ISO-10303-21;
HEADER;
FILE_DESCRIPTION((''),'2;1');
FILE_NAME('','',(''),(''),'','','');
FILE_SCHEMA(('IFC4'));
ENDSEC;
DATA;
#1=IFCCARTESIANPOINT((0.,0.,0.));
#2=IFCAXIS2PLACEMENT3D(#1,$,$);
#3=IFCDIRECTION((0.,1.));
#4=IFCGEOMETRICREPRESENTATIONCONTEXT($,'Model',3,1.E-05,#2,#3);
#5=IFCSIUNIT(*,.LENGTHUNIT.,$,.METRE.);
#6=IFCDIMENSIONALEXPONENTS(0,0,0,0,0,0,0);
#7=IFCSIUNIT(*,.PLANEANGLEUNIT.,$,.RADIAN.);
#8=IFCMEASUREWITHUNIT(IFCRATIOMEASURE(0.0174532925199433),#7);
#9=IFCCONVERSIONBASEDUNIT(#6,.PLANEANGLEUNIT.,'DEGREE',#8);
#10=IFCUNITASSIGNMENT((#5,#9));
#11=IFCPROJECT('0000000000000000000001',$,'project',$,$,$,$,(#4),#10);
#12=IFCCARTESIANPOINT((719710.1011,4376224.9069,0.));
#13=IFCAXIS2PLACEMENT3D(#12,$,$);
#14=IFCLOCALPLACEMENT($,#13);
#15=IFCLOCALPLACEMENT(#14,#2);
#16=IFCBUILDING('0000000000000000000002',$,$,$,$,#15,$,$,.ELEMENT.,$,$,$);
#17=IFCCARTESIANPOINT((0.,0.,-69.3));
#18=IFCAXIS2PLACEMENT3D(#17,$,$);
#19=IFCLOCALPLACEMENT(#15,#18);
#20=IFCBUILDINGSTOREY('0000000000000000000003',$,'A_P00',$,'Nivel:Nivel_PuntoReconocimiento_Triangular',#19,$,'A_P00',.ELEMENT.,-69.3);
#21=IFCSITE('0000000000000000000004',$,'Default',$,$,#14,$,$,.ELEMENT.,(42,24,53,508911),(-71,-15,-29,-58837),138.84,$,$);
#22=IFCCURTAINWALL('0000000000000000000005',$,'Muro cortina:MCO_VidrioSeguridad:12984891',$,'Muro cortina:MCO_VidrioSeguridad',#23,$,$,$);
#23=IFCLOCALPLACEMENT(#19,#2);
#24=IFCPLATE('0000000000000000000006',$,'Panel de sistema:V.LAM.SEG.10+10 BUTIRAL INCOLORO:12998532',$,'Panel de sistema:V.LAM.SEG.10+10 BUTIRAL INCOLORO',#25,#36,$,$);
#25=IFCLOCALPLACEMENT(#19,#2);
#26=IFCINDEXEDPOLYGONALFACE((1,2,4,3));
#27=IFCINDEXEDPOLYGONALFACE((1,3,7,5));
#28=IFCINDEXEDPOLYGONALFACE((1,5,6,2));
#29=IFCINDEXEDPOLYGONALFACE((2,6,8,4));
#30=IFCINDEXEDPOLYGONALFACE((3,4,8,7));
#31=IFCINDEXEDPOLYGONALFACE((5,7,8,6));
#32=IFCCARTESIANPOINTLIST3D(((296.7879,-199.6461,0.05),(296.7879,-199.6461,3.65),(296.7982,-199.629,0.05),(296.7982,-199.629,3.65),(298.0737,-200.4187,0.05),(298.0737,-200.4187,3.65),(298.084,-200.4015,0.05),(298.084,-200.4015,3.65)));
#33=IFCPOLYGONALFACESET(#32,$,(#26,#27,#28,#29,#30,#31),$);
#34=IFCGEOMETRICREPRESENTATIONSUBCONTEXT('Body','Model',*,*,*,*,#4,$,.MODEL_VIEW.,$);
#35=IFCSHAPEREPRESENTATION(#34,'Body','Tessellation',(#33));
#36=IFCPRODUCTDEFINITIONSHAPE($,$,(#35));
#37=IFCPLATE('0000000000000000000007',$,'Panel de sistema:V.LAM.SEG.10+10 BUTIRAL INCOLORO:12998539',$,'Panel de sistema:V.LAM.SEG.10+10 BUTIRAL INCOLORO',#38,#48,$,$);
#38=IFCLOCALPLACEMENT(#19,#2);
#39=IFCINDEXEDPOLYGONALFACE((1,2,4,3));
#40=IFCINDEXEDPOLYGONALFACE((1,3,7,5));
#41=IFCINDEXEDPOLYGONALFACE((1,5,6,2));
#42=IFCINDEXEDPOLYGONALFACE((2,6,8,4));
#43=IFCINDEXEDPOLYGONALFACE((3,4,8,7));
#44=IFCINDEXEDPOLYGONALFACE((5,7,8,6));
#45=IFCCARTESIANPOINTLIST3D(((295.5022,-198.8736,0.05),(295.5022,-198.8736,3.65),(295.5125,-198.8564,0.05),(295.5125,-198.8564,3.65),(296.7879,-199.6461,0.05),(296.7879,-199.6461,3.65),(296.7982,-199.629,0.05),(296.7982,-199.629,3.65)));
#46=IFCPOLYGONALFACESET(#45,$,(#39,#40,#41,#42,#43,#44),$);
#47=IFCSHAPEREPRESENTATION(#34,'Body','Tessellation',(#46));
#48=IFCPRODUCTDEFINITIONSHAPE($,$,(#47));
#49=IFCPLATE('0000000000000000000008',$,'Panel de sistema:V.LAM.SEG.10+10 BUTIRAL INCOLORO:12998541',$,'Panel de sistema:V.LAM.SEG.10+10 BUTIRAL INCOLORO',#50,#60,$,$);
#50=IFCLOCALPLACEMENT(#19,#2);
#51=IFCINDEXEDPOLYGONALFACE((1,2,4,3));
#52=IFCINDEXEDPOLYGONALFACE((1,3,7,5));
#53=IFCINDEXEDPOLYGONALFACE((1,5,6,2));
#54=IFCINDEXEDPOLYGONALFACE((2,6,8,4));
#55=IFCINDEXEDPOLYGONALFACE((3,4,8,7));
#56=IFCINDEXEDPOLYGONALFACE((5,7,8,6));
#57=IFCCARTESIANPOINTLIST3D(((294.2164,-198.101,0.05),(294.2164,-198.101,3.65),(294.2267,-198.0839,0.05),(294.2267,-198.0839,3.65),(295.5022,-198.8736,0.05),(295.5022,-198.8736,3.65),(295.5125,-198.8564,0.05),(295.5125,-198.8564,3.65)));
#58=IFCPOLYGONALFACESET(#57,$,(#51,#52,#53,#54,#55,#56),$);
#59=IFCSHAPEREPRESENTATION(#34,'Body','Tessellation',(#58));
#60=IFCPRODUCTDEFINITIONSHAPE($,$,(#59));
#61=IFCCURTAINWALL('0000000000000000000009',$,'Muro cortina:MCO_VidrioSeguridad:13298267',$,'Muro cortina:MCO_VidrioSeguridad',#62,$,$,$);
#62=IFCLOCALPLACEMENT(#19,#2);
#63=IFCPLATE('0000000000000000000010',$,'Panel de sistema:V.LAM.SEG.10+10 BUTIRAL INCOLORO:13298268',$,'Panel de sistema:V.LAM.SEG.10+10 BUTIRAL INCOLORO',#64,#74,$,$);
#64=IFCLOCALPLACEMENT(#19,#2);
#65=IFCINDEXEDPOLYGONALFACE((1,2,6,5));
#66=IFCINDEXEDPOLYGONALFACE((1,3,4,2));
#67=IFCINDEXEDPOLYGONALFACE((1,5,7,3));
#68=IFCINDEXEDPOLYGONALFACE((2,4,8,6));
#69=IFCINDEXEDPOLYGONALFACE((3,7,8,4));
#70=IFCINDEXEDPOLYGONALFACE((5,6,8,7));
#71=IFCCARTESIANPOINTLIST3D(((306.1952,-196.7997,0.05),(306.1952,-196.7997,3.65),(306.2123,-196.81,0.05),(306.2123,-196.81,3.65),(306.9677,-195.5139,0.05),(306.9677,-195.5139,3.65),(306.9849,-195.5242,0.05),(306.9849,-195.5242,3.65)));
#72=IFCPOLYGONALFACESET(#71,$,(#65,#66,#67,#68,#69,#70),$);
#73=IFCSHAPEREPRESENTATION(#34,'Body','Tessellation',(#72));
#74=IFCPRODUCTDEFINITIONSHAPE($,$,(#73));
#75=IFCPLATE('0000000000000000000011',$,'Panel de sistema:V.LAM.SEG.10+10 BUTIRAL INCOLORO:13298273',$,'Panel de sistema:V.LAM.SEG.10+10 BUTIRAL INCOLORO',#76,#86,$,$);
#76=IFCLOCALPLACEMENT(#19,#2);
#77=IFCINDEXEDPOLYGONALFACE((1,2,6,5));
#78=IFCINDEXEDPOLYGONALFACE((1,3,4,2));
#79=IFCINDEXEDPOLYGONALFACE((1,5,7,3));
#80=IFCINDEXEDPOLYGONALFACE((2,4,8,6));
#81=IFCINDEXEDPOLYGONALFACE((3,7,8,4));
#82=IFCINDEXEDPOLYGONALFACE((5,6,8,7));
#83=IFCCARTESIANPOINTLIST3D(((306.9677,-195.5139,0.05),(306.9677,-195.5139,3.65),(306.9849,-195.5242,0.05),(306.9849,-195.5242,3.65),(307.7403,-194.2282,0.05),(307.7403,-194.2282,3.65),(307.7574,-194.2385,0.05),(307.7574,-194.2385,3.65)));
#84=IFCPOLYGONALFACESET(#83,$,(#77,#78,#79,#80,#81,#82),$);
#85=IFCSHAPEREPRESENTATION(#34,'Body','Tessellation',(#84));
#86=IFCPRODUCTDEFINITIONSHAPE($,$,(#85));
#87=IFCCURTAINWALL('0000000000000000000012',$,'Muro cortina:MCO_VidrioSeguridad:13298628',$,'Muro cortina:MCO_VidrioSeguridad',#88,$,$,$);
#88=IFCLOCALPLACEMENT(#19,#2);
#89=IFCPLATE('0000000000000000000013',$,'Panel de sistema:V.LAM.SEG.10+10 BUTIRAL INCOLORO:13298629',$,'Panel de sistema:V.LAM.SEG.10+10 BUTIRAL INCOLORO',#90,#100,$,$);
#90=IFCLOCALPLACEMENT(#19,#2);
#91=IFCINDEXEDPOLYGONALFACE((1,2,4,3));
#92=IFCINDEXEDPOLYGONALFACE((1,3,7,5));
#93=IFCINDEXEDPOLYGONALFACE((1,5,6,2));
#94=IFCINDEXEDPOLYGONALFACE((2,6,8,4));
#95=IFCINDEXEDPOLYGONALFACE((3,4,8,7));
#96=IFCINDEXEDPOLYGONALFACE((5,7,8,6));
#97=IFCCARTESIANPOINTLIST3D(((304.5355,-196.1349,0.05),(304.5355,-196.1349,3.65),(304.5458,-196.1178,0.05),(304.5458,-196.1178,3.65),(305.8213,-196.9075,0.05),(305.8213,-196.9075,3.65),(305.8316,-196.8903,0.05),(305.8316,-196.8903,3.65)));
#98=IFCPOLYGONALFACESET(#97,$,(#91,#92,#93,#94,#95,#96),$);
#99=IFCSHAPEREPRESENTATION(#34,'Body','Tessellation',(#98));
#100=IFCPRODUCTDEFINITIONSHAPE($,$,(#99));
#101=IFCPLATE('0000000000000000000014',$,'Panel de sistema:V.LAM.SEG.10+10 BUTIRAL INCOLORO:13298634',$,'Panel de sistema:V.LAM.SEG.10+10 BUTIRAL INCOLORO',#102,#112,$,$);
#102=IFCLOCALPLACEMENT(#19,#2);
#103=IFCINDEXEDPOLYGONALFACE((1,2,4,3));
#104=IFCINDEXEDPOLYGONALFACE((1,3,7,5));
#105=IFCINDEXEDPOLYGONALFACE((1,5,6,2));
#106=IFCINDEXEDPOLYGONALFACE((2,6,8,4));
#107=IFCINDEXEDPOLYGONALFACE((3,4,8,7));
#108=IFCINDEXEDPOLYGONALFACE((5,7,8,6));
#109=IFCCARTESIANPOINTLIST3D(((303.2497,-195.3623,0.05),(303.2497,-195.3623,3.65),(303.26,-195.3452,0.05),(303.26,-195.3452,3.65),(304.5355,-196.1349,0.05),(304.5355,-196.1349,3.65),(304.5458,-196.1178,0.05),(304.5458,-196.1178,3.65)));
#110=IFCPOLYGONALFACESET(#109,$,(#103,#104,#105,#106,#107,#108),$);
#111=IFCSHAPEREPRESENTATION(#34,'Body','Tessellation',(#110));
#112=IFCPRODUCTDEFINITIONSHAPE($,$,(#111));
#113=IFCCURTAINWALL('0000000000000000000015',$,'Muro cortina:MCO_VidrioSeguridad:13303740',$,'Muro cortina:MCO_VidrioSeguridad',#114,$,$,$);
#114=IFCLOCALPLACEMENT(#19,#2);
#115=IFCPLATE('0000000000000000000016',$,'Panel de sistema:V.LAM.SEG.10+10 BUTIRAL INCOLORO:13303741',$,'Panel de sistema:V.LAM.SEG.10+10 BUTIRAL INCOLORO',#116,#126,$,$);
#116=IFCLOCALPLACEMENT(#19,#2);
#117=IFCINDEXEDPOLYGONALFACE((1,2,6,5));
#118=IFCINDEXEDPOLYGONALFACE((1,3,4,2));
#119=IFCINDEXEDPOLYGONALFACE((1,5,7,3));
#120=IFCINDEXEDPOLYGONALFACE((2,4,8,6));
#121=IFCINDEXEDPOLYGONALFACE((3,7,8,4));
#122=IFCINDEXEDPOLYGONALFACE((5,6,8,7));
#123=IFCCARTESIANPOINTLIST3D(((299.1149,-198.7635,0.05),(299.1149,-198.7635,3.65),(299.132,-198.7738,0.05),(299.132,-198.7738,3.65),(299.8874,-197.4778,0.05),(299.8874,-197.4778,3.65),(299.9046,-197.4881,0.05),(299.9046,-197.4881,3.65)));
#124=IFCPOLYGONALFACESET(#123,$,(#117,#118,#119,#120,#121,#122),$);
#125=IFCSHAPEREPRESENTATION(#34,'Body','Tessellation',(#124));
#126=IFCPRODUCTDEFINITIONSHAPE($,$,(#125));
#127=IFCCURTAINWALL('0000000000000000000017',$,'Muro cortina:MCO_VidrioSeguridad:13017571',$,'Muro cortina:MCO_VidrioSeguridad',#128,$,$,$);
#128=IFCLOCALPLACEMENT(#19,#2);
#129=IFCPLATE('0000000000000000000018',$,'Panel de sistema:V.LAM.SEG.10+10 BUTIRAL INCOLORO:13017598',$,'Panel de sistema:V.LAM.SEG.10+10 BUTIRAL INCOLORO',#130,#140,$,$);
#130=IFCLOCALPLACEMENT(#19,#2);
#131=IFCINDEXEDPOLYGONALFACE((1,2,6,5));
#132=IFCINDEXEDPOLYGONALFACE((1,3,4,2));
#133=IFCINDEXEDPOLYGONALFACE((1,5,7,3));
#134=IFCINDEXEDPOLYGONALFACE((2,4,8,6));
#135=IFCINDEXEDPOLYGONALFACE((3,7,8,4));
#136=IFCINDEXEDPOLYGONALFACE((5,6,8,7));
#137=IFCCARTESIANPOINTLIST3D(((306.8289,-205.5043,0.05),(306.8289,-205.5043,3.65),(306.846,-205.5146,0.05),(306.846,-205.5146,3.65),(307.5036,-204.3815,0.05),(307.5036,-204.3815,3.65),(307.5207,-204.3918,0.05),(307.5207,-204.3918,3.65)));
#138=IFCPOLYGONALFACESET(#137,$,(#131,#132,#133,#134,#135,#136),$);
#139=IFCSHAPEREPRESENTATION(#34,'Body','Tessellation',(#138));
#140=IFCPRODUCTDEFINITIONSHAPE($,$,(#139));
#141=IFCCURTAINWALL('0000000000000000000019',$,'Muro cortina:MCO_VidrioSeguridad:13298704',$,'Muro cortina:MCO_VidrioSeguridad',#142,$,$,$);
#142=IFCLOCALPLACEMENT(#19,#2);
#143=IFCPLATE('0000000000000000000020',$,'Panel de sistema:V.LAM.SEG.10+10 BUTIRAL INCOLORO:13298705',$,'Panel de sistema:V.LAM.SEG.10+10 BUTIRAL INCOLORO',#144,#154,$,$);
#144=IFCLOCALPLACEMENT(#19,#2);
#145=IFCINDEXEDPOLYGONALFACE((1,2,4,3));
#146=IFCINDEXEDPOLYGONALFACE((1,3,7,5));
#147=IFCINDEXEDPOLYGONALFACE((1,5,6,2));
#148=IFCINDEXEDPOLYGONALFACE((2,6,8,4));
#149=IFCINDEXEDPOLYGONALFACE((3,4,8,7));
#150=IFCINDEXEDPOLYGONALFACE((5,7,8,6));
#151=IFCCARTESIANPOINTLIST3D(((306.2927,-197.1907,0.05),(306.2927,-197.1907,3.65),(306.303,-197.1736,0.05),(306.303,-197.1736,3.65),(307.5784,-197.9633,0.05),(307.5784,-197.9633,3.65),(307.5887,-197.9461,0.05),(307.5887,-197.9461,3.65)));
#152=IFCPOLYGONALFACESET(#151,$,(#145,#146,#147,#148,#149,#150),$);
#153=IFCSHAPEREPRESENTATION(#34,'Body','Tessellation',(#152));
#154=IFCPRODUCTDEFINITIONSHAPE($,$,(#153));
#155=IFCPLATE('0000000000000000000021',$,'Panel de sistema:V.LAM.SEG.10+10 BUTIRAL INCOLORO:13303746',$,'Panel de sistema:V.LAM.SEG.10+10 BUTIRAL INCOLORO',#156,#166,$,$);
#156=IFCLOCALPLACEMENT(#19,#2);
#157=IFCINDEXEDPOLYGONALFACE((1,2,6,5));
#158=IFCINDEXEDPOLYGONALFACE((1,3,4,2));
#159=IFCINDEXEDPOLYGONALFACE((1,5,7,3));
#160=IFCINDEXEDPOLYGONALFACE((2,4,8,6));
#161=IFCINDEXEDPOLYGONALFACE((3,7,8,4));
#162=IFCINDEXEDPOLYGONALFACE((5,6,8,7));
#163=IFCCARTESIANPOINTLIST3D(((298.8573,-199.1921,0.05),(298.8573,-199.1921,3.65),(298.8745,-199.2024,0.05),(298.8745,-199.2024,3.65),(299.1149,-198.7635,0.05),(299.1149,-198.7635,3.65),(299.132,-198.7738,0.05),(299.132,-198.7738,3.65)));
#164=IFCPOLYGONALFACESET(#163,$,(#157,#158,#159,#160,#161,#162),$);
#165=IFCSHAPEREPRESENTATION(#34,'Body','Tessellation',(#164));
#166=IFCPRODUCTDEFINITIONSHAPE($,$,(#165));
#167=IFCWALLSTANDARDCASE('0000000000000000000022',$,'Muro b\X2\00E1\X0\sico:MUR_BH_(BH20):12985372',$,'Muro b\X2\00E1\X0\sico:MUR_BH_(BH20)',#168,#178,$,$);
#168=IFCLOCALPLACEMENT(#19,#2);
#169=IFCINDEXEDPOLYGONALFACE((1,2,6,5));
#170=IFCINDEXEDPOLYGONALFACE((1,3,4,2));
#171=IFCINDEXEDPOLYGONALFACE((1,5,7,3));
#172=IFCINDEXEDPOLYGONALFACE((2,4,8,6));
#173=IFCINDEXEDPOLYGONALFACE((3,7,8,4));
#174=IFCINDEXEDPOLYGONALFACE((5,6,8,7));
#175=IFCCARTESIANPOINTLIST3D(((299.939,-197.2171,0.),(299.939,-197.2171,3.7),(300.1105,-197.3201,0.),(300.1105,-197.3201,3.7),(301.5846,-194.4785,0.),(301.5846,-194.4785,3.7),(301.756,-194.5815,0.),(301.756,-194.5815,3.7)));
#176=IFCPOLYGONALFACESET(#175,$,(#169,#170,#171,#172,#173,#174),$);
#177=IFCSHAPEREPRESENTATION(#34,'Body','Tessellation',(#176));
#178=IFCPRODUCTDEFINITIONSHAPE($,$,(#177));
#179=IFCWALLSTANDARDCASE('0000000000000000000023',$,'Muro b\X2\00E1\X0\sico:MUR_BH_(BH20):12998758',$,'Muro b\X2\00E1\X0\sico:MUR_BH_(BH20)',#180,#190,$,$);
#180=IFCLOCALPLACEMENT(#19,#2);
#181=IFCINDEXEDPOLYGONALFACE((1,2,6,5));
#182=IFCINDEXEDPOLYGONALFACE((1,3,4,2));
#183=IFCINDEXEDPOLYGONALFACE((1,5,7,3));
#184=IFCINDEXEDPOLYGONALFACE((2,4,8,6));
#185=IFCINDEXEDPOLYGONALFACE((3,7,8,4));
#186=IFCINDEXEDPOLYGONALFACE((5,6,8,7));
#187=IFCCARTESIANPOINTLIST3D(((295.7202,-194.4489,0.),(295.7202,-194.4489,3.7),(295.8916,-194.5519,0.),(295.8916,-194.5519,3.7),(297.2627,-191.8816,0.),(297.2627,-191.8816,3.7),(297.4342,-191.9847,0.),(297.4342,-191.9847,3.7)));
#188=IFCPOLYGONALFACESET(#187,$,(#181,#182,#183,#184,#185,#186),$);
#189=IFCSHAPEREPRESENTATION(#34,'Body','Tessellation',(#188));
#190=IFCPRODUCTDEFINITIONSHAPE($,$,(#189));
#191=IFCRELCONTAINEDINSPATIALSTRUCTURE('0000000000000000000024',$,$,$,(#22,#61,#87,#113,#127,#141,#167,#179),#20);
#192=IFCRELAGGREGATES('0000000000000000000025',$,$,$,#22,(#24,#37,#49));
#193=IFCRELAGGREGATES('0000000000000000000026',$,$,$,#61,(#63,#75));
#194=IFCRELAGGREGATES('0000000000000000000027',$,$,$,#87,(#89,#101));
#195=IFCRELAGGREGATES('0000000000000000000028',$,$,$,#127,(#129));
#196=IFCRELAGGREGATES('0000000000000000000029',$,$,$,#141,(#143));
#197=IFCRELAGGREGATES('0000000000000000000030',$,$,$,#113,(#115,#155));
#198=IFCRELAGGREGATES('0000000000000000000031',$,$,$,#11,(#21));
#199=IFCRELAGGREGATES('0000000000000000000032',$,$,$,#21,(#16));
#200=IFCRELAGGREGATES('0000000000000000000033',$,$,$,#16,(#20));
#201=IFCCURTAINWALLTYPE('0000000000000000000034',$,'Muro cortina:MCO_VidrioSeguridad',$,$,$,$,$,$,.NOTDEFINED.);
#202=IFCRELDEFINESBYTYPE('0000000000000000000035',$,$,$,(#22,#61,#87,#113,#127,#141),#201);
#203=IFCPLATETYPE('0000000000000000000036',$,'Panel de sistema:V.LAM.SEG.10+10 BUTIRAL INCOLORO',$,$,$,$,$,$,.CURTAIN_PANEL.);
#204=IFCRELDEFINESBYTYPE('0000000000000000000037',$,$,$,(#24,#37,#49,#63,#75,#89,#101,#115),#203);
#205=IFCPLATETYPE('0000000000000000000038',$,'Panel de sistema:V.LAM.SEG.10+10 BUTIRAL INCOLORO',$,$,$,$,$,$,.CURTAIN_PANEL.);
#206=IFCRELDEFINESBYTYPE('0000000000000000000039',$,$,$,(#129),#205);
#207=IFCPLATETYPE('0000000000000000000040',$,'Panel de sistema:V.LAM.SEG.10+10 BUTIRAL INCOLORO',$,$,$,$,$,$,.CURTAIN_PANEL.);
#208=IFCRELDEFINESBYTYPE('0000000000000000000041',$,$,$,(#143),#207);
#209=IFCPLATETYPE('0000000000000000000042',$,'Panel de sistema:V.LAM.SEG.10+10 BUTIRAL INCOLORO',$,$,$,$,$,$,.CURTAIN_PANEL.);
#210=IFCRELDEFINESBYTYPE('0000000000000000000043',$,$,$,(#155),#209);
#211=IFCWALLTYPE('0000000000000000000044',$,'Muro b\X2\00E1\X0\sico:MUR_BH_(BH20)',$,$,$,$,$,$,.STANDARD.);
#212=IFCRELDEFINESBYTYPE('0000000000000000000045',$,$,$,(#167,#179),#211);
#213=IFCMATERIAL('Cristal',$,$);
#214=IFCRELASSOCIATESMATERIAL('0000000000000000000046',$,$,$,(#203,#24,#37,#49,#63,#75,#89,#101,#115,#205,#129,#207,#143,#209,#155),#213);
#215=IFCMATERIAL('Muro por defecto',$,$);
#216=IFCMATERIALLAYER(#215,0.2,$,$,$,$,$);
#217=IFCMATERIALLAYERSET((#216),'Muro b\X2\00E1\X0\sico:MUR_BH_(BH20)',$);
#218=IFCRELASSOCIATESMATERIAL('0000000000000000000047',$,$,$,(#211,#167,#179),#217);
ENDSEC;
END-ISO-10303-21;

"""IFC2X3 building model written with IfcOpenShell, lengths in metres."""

from ifc_helpers import new_model, entity, si_unit, converted_unit, direction, frame, frame_2d, origin, origin_2d_with_axis, place, context, subcontext, project, spatial, rectangle, extrude, source, transform, mapped, material, layer, layer_set, layer_usage, type_object, type_shapes, element, aggregate, save


model = new_model("IFC2X3")

# Units and contexts
model_context = context("Model", 3, precision=1e-05, world=origin(), true_north=direction((0.0, 1.0)))
body_context = subcontext(model_context, "Body", "Model", "MODEL_VIEW")
ifc_project = project(units=[si_unit("LENGTHUNIT", "METRE"), converted_unit("PLANEANGLEUNIT", "DEGREE", entity("IfcRatioMeasure", 0.0174532925199433), si_unit("PLANEANGLEUNIT", "RADIAN"), dimensions=[0, 0, 0, 0, 0, 0, 0])], contexts=[model_context])

# Site, building, storey
site_placement = place(None, frame((719710.1011, 4376224.9069, 0.0)))
site = spatial("IfcSite", under=ifc_project, at=site_placement, Name="Default", CompositionType="ELEMENT", RefLatitude=(42, 24, 53, 508911), RefLongitude=(-71, -15, -29, -58837), RefElevation=138.84)
building_placement = place(site_placement, origin())
building = spatial("IfcBuilding", under=site, at=building_placement, CompositionType="ELEMENT")
storey_placement = place(building_placement, frame((0.0, 0.0, -69.3)))
storey = spatial("IfcBuildingStorey", under=building, at=storey_placement, Name="A_P00", ObjectType="Nivel:Nivel_PuntoReconocimiento_Triangular", LongName="A_P00", CompositionType="ELEMENT", Elevation=-69.3)

# Curtain walls, plates
curtain_wall_type = type_object("IfcCurtainWallType", Name="Muro cortina:MCO_VidrioSeguridad", PredefinedType="NOTDEFINED")
curtain_wall_1_placement = place(storey_placement, frame((0.0, 0.0, 69.3)))
curtain_wall_1 = element("IfcCurtainWall", 1, at=curtain_wall_1_placement, inside=storey, type_object=curtain_wall_type, Name="Muro cortina:MCO_VidrioSeguridad:12984891", ObjectType="Muro cortina:MCO_VidrioSeguridad")
ifc_material_1 = material(Name="Cristal")
plate_type_1 = type_object("IfcPlateType", Name="Panel de sistema:V.LAM.SEG.10+10 BUTIRAL INCOLORO", PredefinedType="CURTAIN_PANEL", material=ifc_material_1)
shared_shape_1 = source(origin(), body_context, "Body", "SweptSolid", [
    extrude(rectangle(XDim=0.02, YDim=1.5, at=origin_2d_with_axis()), frame((0.0, 0.0, 0.0), z_axis=(0.0, 0.0, 1.0), x_axis=(0.0, 1.0, 0.0)), (0.0, 0.0, 1.0), 3.6),
])
type_shapes(plate_type_1, [shared_shape_1])
plate_1_placement = place(curtain_wall_1_placement, frame((297.4359, -200.0238, -69.25), z_axis=(0.0, 0.0, 1.0), x_axis=(-0.857167, 0.515038, 0.0)))
plate_1 = element("IfcPlate", 2, at=plate_1_placement, type_object=plate_type_1, material=ifc_material_1, Name="Panel de sistema:V.LAM.SEG.10+10 BUTIRAL INCOLORO:12998532", ObjectType="Panel de sistema:V.LAM.SEG.10+10 BUTIRAL INCOLORO", context=body_context, shape_type="MappedRepresentation", body=[
    mapped(shared_shape_1, transform((0.0, 0.0, 0.0), scale=1.0)),
])
plate_2_placement = place(curtain_wall_1_placement, frame((296.1502, -199.2513, -69.25), z_axis=(0.0, 0.0, 1.0), x_axis=(-0.857167, 0.515038, 0.0)))
plate_2 = element("IfcPlate", 3, at=plate_2_placement, type_object=plate_type_1, material=ifc_material_1, Name="Panel de sistema:V.LAM.SEG.10+10 BUTIRAL INCOLORO:12998539", ObjectType="Panel de sistema:V.LAM.SEG.10+10 BUTIRAL INCOLORO", context=body_context, shape_type="MappedRepresentation", body=[
    mapped(shared_shape_1, transform((0.0, 0.0, 0.0), scale=1.0)),
])
plate_3_placement = place(curtain_wall_1_placement, frame((294.8644, -198.4787, -69.25), z_axis=(0.0, 0.0, 1.0), x_axis=(-0.857167, 0.515038, 0.0)))
plate_3 = element("IfcPlate", 4, at=plate_3_placement, type_object=plate_type_1, material=ifc_material_1, Name="Panel de sistema:V.LAM.SEG.10+10 BUTIRAL INCOLORO:12998541", ObjectType="Panel de sistema:V.LAM.SEG.10+10 BUTIRAL INCOLORO", context=body_context, shape_type="MappedRepresentation", body=[
    mapped(shared_shape_1, transform((0.0, 0.0, 0.0), scale=1.0)),
])
aggregate(curtain_wall_1, [plate_1, plate_2, plate_3])
curtain_wall_2_placement = place(storey_placement, frame((0.0, 0.0, 69.3)))
curtain_wall_2 = element("IfcCurtainWall", 5, at=curtain_wall_2_placement, inside=storey, type_object=curtain_wall_type, Name="Muro cortina:MCO_VidrioSeguridad:13298267", ObjectType="Muro cortina:MCO_VidrioSeguridad")
plate_4_placement = place(curtain_wall_2_placement, frame((306.59, -196.1619, -69.25), z_axis=(0.0, 0.0, 1.0), x_axis=(0.515038, 0.857167, 0.0)))
plate_4 = element("IfcPlate", 6, at=plate_4_placement, type_object=plate_type_1, material=ifc_material_1, Name="Panel de sistema:V.LAM.SEG.10+10 BUTIRAL INCOLORO:13298268", ObjectType="Panel de sistema:V.LAM.SEG.10+10 BUTIRAL INCOLORO", context=body_context, shape_type="MappedRepresentation", body=[
    mapped(shared_shape_1, transform((0.0, 0.0, 0.0), scale=1.0)),
])
plate_5_placement = place(curtain_wall_2_placement, frame((307.3626, -194.8762, -69.25), z_axis=(0.0, 0.0, 1.0), x_axis=(0.515038, 0.857167, 0.0)))
plate_5 = element("IfcPlate", 7, at=plate_5_placement, type_object=plate_type_1, material=ifc_material_1, Name="Panel de sistema:V.LAM.SEG.10+10 BUTIRAL INCOLORO:13298273", ObjectType="Panel de sistema:V.LAM.SEG.10+10 BUTIRAL INCOLORO", context=body_context, shape_type="MappedRepresentation", body=[
    mapped(shared_shape_1, transform((0.0, 0.0, 0.0), scale=1.0)),
])
aggregate(curtain_wall_2, [plate_4, plate_5])
curtain_wall_3_placement = place(storey_placement, frame((0.0, 0.0, 69.3)))
curtain_wall_3 = element("IfcCurtainWall", 8, at=curtain_wall_3_placement, inside=storey, type_object=curtain_wall_type, Name="Muro cortina:MCO_VidrioSeguridad:13298628", ObjectType="Muro cortina:MCO_VidrioSeguridad")
plate_6_placement = place(curtain_wall_3_placement, frame((305.1835, -196.5126, -69.25), z_axis=(0.0, 0.0, 1.0), x_axis=(-0.857167, 0.515038, 0.0)))
plate_6 = element("IfcPlate", 9, at=plate_6_placement, type_object=plate_type_1, material=ifc_material_1, Name="Panel de sistema:V.LAM.SEG.10+10 BUTIRAL INCOLORO:13298629", ObjectType="Panel de sistema:V.LAM.SEG.10+10 BUTIRAL INCOLORO", context=body_context, shape_type="MappedRepresentation", body=[
    mapped(shared_shape_1, transform((0.0, 0.0, 0.0), scale=1.0)),
])
plate_7_placement = place(curtain_wall_3_placement, frame((303.8978, -195.7401, -69.25), z_axis=(0.0, 0.0, 1.0), x_axis=(-0.857167, 0.515038, 0.0)))
plate_7 = element("IfcPlate", 10, at=plate_7_placement, type_object=plate_type_1, material=ifc_material_1, Name="Panel de sistema:V.LAM.SEG.10+10 BUTIRAL INCOLORO:13298634", ObjectType="Panel de sistema:V.LAM.SEG.10+10 BUTIRAL INCOLORO", context=body_context, shape_type="MappedRepresentation", body=[
    mapped(shared_shape_1, transform((0.0, 0.0, 0.0), scale=1.0)),
])
aggregate(curtain_wall_3, [plate_6, plate_7])

# Curtain walls, plates
curtain_wall_4_placement = place(storey_placement, frame((0.0, 0.0, 69.3)))
curtain_wall_4 = element("IfcCurtainWall", 11, at=curtain_wall_4_placement, inside=storey, type_object=curtain_wall_type, Name="Muro cortina:MCO_VidrioSeguridad:13303740", ObjectType="Muro cortina:MCO_VidrioSeguridad")
plate_8_placement = place(curtain_wall_4_placement, frame((299.5097, -198.1258, -69.25), z_axis=(0.0, 0.0, 1.0), x_axis=(-0.515038, -0.857167, 0.0)))
plate_8 = element("IfcPlate", 12, at=plate_8_placement, type_object=plate_type_1, material=ifc_material_1, Name="Panel de sistema:V.LAM.SEG.10+10 BUTIRAL INCOLORO:13303741", ObjectType="Panel de sistema:V.LAM.SEG.10+10 BUTIRAL INCOLORO", context=body_context, shape_type="MappedRepresentation", body=[
    mapped(shared_shape_1, transform((0.0, 0.0, 0.0), scale=1.0)),
])
curtain_wall_5_placement = place(storey_placement, frame((0.0, 0.0, 69.3)))
curtain_wall_5 = element("IfcCurtainWall", 13, at=curtain_wall_5_placement, inside=storey, type_object=curtain_wall_type, Name="Muro cortina:MCO_VidrioSeguridad:13017571", ObjectType="Muro cortina:MCO_VidrioSeguridad")
plate_type_2 = type_object("IfcPlateType", Name="Panel de sistema:V.LAM.SEG.10+10 BUTIRAL INCOLORO", PredefinedType="CURTAIN_PANEL", material=ifc_material_1)
shared_shape_2 = source(origin(), body_context, "Body", "SweptSolid", [
    extrude(rectangle(XDim=0.02, YDim=1.31, at=origin_2d_with_axis()), frame((0.0, 0.0, 0.0), z_axis=(0.0, 0.0, 1.0), x_axis=(0.0, 1.0, 0.0)), (0.0, 0.0, 1.0), 3.6),
])
type_shapes(plate_type_2, [shared_shape_2])
plate_9_placement = place(curtain_wall_5_placement, frame((307.1748, -204.9481, -69.25), z_axis=(0.0, 0.0, 1.0), x_axis=(-0.515038, -0.857167, 0.0)))
plate_9 = element("IfcPlate", 14, at=plate_9_placement, type_object=plate_type_2, material=ifc_material_1, Name="Panel de sistema:V.LAM.SEG.10+10 BUTIRAL INCOLORO:13017598", ObjectType="Panel de sistema:V.LAM.SEG.10+10 BUTIRAL INCOLORO", context=body_context, shape_type="MappedRepresentation", body=[
    mapped(shared_shape_2, transform((0.0, 0.0, 0.0), scale=1.0)),
])
aggregate(curtain_wall_5, [plate_9])
curtain_wall_6_placement = place(storey_placement, frame((0.0, 0.0, 69.3)))
curtain_wall_6 = element("IfcCurtainWall", 15, at=curtain_wall_6_placement, inside=storey, type_object=curtain_wall_type, Name="Muro cortina:MCO_VidrioSeguridad:13298704", ObjectType="Muro cortina:MCO_VidrioSeguridad")
plate_type_3 = type_object("IfcPlateType", Name="Panel de sistema:V.LAM.SEG.10+10 BUTIRAL INCOLORO", PredefinedType="CURTAIN_PANEL", material=ifc_material_1)
shared_shape_3 = source(origin(), body_context, "Body", "SweptSolid", [
    extrude(rectangle(XDim=0.02, YDim=1.5, at=frame_2d((0.0, 0.0), x_axis=(1.0, 0.0))), frame((0.0, 0.0, 0.0), z_axis=(0.0, 0.0, 1.0), x_axis=(0.0, 1.0, 0.0)), (0.0, 0.0, 1.0), 3.6),
])
type_shapes(plate_type_3, [shared_shape_3])
plate_10_placement = place(curtain_wall_6_placement, frame((306.9407, -197.5684, -69.25), z_axis=(0.0, 0.0, 1.0), x_axis=(0.857167, -0.515038, 0.0)))
plate_10 = element("IfcPlate", 16, at=plate_10_placement, type_object=plate_type_3, material=ifc_material_1, Name="Panel de sistema:V.LAM.SEG.10+10 BUTIRAL INCOLORO:13298705", ObjectType="Panel de sistema:V.LAM.SEG.10+10 BUTIRAL INCOLORO", context=body_context, shape_type="MappedRepresentation", body=[
    mapped(shared_shape_3, transform((0.0, 0.0, 0.0), scale=1.0)),
])
aggregate(curtain_wall_6, [plate_10])

# Plate
plate_type_4 = type_object("IfcPlateType", Name="Panel de sistema:V.LAM.SEG.10+10 BUTIRAL INCOLORO", PredefinedType="CURTAIN_PANEL", material=ifc_material_1)
shared_shape_4 = source(origin(), body_context, "Body", "SweptSolid", [
    extrude(rectangle(XDim=0.02, YDim=0.5, at=origin_2d_with_axis()), frame((0.0, 0.0, 0.0), z_axis=(0.0, 0.0, 1.0), x_axis=(0.0, 1.0, 0.0)), (0.0, 0.0, 1.0), 3.6),
])
type_shapes(plate_type_4, [shared_shape_4])
plate_11_placement = place(curtain_wall_4_placement, frame((298.9947, -198.983, -69.25), z_axis=(0.0, 0.0, 1.0), x_axis=(-0.515038, -0.857167, 0.0)))
plate_11 = element("IfcPlate", 17, at=plate_11_placement, type_object=plate_type_4, material=ifc_material_1, Name="Panel de sistema:V.LAM.SEG.10+10 BUTIRAL INCOLORO:13303746", ObjectType="Panel de sistema:V.LAM.SEG.10+10 BUTIRAL INCOLORO", context=body_context, shape_type="MappedRepresentation", body=[
    mapped(shared_shape_4, transform((0.0, 0.0, 0.0), scale=1.0)),
])
aggregate(curtain_wall_4, [plate_8, plate_11])

# Wall
ifc_material_2 = material(Name="Muro por defecto")
ifc_layer = layer(ifc_material_2, 0.2)
ifc_layer_set = layer_set([ifc_layer], Name="Muro básico:MUR_BH_(BH20)")
ifc_layer_usage_1 = layer_usage(ifc_layer_set, "AXIS2", "NEGATIVE", 0.1)
wall_type = type_object("IfcWallType", Name="Muro básico:MUR_BH_(BH20)", PredefinedType="STANDARD", material=ifc_layer_set)
wall_1_placement = place(storey_placement, frame((301.6703, -194.53, 0.0), z_axis=(0.0, 0.0, 1.0), x_axis=(-0.515038, -0.857167, 0.0)))
element("IfcWallStandardCase", 18, at=wall_1_placement, inside=storey, type_object=wall_type, material=ifc_layer_usage_1, Name="Muro básico:MUR_BH_(BH20):12985372", ObjectType="Muro básico:MUR_BH_(BH20)", context=body_context, shape_type="SweptSolid", body=[
    extrude(rectangle(XDim=3.195, YDim=0.2, at=frame_2d((1.5975, 0.0), x_axis=(-1.0, 0.0))), origin(), (0.0, 0.0, 1.0), 3.7),
])

# Wall
ifc_layer_usage_2 = layer_usage(ifc_layer_set, "AXIS2", "NEGATIVE", 0.1)
wall_2_placement = place(storey_placement, frame((297.3485, -191.9332, 0.0), z_axis=(0.0, 0.0, 1.0), x_axis=(-0.515038, -0.857167, 0.0)))
element("IfcWallStandardCase", 19, at=wall_2_placement, inside=storey, type_object=wall_type, material=ifc_layer_usage_2, Name="Muro básico:MUR_BH_(BH20):12998758", ObjectType="Muro básico:MUR_BH_(BH20)", context=body_context, shape_type="SweptSolid", body=[
    extrude(rectangle(XDim=2.995, YDim=0.2, at=frame_2d((1.4975, 0.0), x_axis=(-1.0, 0.0))), origin(), (0.0, 0.0, 1.0), 3.7),
])

save(model, "model.ifc")
